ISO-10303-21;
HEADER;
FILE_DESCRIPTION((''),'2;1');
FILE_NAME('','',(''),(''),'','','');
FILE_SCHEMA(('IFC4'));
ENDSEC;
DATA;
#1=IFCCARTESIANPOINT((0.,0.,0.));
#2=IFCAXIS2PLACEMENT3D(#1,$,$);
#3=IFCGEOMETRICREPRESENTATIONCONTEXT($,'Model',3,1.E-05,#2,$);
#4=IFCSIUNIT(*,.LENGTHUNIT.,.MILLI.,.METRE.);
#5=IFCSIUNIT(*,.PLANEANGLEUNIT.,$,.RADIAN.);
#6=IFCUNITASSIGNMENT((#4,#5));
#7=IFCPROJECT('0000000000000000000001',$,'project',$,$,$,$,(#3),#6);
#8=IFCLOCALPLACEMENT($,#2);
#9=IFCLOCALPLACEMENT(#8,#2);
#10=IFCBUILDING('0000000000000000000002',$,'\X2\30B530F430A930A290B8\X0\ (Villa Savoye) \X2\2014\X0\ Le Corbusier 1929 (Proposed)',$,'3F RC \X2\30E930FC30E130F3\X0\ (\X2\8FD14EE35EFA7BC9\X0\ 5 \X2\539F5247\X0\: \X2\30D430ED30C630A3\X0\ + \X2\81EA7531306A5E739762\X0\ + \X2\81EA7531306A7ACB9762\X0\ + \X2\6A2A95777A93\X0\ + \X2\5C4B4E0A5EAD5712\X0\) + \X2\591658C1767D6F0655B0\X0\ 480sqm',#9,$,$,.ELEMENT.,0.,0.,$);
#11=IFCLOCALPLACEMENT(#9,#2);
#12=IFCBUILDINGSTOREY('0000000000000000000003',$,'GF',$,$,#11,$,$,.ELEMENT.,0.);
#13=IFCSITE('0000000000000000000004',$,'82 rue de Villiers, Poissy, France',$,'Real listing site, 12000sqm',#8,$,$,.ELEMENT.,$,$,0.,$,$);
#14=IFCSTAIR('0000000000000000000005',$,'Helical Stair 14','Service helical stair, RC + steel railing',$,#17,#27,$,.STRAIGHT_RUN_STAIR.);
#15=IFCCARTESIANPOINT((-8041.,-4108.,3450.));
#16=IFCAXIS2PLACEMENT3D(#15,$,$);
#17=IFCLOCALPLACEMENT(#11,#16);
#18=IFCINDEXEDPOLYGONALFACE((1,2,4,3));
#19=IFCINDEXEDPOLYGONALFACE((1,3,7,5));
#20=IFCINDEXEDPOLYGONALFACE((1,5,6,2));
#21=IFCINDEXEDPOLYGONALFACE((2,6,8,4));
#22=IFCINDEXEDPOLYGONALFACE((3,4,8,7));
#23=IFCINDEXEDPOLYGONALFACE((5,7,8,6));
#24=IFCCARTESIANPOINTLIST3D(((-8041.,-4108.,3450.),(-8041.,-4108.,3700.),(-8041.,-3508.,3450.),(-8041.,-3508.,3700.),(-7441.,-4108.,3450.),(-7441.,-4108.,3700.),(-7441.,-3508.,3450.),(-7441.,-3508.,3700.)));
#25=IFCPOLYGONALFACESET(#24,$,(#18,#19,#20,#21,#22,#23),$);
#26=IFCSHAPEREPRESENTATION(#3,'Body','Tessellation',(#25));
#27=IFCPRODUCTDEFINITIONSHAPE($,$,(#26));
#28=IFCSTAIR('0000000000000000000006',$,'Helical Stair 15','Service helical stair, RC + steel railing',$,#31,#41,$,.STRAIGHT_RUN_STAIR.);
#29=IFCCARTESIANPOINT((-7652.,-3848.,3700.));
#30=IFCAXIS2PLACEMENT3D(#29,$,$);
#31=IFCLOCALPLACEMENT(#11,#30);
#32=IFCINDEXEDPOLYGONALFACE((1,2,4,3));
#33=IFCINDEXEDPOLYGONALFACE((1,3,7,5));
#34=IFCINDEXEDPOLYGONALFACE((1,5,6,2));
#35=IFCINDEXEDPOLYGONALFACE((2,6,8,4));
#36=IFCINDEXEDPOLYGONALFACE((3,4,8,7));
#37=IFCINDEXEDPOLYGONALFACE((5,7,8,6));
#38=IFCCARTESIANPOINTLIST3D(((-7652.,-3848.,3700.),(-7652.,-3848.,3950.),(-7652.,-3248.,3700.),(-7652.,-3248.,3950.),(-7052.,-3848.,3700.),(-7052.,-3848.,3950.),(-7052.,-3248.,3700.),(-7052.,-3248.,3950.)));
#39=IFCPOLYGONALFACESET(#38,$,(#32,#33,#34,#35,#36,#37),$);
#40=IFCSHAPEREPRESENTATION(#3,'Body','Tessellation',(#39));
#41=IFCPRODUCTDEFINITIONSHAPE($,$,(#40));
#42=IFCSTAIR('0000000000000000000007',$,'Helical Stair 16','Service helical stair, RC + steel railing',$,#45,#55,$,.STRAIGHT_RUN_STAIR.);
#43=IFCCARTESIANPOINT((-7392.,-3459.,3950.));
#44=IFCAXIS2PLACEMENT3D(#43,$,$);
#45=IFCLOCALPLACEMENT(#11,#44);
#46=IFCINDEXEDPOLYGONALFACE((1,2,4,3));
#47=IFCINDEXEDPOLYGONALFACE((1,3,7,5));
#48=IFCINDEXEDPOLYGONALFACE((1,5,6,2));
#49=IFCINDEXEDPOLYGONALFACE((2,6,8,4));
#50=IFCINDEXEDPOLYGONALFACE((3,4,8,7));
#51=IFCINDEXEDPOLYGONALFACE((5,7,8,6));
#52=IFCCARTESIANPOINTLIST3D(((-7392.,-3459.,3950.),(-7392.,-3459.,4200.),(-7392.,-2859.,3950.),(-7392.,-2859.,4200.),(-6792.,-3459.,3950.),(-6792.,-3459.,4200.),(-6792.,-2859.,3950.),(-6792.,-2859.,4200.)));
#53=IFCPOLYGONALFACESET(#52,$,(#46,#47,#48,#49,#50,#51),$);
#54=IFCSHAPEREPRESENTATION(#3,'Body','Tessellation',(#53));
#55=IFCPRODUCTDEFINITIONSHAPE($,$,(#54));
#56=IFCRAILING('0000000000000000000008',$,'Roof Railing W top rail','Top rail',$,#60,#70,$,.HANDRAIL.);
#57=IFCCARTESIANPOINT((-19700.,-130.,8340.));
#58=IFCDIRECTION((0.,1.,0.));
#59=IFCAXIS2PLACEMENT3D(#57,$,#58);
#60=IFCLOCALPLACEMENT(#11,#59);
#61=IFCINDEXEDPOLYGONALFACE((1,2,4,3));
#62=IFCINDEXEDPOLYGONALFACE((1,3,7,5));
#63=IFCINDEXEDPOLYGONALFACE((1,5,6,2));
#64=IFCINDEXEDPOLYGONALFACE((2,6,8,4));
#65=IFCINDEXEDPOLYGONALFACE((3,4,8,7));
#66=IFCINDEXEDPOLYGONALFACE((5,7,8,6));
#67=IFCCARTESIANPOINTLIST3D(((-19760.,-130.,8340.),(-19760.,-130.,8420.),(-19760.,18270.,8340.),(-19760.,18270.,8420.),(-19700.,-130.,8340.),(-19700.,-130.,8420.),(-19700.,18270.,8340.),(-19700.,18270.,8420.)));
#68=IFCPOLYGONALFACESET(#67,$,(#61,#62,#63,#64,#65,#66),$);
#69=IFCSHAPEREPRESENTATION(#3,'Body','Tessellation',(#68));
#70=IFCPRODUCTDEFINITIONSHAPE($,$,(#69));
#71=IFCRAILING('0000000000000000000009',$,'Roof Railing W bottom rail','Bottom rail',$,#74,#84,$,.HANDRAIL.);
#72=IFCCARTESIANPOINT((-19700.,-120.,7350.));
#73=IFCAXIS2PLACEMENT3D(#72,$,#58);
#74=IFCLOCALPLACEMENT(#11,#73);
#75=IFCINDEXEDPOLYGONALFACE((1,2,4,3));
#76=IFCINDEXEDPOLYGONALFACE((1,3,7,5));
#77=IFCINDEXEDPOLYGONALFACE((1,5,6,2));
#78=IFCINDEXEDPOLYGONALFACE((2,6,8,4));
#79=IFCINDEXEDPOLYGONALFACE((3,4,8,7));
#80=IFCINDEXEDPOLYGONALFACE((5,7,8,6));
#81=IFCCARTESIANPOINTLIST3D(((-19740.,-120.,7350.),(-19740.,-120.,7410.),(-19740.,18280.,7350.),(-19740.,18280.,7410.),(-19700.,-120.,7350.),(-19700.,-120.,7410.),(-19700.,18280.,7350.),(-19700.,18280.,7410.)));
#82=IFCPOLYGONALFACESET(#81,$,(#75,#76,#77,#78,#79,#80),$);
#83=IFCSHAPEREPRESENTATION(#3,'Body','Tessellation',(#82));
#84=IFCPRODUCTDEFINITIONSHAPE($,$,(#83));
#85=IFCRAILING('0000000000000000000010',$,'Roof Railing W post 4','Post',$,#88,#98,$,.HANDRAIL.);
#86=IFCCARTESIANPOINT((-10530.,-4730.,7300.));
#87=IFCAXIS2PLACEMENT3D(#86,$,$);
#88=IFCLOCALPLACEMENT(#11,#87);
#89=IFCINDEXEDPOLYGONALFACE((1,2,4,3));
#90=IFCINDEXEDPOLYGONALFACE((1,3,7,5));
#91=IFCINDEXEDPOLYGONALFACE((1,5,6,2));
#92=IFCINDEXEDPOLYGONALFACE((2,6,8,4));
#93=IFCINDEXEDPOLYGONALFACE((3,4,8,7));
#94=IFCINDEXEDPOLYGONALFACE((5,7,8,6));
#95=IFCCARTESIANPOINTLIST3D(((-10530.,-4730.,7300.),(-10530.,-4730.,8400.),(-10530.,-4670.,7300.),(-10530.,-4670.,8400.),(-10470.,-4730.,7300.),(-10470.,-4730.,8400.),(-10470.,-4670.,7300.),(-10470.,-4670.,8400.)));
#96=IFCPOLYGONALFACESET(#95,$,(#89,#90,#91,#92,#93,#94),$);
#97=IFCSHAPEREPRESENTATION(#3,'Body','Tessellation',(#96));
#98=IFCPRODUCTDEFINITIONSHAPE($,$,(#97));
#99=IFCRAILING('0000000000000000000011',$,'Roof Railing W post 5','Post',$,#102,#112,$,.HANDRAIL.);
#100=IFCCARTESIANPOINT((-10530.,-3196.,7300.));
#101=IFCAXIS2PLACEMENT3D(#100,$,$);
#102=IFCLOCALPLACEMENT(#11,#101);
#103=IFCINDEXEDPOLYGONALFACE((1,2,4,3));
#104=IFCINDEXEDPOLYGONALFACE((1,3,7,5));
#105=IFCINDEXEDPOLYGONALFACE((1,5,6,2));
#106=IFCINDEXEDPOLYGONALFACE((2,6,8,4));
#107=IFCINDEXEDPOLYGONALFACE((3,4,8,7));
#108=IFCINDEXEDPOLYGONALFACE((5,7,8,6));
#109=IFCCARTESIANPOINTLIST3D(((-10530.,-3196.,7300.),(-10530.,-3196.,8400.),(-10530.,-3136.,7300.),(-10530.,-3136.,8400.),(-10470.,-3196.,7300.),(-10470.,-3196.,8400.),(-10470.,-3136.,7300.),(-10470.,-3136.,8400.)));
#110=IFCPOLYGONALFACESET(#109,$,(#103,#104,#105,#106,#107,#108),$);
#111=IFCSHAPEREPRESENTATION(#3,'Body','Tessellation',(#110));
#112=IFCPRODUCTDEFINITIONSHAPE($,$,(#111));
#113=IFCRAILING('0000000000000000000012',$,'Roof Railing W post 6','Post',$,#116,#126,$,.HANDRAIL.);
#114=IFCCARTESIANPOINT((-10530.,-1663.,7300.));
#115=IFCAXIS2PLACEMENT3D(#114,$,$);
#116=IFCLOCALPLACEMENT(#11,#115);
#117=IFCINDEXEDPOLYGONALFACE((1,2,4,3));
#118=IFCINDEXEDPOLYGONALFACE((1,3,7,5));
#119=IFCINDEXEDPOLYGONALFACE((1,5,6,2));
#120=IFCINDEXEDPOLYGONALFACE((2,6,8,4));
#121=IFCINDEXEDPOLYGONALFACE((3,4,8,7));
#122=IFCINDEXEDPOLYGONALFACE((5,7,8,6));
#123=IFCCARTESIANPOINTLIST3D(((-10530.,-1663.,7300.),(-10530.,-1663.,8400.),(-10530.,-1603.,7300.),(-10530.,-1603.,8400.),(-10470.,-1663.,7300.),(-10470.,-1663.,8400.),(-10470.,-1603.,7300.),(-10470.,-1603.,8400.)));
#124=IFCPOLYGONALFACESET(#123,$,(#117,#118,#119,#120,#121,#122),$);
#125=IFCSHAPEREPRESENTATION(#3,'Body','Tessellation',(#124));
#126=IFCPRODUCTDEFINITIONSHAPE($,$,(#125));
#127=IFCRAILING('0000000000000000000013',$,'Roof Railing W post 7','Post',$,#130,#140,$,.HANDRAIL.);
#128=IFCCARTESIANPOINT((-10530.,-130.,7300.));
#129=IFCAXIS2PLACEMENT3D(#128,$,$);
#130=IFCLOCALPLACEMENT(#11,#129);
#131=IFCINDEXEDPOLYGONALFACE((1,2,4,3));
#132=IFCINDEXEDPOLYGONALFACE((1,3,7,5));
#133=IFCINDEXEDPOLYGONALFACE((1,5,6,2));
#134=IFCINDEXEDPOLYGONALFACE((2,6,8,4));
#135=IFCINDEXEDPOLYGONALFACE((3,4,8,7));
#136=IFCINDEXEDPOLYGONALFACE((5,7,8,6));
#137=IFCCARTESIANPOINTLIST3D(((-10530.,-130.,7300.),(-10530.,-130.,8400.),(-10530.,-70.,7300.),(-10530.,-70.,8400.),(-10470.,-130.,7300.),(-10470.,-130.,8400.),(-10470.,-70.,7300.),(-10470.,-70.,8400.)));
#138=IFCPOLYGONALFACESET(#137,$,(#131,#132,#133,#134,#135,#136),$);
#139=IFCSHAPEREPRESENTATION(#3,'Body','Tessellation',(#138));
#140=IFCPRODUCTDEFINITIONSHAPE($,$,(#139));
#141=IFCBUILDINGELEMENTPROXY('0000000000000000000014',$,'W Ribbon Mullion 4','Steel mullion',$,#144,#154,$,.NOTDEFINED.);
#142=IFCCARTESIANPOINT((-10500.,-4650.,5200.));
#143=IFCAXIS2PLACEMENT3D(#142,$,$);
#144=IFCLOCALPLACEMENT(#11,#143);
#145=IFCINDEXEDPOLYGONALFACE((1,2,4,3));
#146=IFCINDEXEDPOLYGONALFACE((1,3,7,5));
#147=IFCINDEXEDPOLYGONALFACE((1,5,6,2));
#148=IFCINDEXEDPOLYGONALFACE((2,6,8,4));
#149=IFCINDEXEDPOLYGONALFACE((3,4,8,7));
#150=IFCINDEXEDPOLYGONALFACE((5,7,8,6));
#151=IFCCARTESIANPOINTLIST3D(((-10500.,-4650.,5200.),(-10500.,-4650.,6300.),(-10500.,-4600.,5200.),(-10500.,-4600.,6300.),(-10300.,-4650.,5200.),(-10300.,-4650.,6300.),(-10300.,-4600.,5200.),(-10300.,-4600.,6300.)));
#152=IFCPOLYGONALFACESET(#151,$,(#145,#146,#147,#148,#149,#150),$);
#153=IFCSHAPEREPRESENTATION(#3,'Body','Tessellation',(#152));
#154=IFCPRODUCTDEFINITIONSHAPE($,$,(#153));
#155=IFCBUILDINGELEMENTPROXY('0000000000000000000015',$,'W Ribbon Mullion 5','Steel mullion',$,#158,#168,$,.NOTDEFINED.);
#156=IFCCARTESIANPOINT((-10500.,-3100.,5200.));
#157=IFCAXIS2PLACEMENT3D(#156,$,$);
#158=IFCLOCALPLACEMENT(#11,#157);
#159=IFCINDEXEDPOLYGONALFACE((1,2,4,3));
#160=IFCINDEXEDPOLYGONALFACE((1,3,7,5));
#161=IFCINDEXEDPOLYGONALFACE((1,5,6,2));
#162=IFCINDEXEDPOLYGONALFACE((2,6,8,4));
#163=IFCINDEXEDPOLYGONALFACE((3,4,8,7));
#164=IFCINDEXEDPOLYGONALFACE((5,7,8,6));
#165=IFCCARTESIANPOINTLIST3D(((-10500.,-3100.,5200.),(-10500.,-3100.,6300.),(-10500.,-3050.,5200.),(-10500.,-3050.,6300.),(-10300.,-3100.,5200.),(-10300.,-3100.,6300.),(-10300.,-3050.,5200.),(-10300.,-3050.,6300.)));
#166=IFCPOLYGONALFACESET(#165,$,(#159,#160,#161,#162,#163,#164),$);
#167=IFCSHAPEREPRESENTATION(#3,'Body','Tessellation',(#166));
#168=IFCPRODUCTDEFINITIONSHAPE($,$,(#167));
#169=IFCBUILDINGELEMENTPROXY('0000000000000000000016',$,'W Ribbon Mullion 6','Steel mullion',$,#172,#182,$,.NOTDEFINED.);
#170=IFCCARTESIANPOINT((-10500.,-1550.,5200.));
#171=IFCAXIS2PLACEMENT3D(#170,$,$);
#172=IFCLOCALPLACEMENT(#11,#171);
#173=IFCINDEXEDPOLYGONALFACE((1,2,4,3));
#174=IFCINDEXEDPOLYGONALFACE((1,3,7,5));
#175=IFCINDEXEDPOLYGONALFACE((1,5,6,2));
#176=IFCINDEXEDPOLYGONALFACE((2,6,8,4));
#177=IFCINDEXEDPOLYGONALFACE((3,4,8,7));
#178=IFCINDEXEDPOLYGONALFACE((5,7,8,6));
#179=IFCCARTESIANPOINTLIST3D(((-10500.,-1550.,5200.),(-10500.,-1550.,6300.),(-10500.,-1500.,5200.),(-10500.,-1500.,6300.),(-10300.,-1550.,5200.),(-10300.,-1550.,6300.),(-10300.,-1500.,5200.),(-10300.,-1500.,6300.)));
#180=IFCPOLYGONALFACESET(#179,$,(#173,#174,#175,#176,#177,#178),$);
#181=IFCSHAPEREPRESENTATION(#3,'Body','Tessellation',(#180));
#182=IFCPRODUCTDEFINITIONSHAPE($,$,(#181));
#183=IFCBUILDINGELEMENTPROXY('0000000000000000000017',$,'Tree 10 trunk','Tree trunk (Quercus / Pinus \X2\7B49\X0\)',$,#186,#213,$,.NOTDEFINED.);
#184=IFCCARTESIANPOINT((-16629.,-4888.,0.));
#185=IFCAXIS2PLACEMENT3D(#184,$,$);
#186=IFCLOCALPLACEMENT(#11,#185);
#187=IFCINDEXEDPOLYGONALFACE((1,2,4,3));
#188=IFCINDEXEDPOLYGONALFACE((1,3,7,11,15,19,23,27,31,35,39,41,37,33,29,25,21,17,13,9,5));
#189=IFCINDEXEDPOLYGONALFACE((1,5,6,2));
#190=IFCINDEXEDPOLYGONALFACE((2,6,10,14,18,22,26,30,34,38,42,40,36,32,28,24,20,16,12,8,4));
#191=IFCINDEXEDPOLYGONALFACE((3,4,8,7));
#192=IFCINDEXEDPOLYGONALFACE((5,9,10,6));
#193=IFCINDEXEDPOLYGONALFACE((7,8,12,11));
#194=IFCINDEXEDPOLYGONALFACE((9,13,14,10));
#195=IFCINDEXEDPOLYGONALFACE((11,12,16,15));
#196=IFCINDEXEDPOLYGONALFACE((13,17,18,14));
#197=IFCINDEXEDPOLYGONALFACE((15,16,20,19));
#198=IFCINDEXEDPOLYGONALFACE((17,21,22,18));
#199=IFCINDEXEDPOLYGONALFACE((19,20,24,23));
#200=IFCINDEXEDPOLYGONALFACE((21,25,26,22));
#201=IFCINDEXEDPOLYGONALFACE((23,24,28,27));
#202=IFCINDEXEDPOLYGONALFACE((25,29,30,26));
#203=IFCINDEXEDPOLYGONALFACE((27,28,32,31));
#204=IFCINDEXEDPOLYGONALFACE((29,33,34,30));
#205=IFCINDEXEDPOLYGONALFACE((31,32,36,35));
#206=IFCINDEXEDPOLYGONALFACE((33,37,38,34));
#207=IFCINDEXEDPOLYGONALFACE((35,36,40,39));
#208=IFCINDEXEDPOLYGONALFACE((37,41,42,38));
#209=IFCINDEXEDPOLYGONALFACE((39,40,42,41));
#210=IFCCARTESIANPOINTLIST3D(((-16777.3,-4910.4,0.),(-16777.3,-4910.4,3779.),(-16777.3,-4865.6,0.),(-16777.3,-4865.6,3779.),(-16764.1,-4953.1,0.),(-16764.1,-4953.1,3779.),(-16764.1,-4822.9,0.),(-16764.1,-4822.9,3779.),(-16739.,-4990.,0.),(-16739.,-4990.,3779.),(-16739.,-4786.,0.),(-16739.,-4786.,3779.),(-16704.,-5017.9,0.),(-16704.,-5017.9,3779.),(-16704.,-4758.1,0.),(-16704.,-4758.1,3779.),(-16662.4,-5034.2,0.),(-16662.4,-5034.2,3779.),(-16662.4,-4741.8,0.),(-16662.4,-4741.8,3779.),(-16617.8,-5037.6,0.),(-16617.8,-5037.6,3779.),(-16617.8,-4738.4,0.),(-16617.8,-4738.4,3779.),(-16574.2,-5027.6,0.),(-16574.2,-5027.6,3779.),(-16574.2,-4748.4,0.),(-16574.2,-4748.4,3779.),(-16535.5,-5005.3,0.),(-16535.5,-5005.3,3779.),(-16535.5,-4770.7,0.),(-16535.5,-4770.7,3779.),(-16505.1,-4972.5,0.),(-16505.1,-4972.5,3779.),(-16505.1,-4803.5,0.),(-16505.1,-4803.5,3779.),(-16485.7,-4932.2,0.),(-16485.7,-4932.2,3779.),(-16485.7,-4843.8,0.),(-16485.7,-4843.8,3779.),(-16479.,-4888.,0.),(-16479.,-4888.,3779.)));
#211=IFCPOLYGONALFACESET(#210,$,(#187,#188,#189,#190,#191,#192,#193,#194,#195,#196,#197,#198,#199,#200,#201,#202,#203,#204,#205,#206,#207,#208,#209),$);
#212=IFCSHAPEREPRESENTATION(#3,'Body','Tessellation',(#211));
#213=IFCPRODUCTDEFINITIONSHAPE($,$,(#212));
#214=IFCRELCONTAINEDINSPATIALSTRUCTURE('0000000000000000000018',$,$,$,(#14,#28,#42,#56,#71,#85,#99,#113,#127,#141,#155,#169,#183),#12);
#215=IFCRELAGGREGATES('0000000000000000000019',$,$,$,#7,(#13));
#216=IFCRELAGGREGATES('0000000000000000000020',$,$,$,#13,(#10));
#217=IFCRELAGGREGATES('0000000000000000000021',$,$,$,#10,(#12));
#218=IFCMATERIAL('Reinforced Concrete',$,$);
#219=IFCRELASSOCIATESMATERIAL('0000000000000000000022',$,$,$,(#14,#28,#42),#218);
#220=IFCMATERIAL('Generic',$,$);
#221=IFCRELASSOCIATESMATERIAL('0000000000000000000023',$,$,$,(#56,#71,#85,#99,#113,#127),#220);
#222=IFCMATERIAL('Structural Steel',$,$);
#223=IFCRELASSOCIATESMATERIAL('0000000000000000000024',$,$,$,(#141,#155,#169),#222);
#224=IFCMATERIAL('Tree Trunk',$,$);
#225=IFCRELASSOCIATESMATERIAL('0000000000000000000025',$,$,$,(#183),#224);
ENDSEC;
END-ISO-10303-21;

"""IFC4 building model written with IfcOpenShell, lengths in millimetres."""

from ifc_helpers import new_model, si_unit, frame, frame_2d, origin, origin_2d, place, context, project, spatial, rectangle, circle, extrude, material, element, save


model = new_model("IFC4")

# Units and contexts
model_context = context("Model", 3, precision=1e-05, world=origin())
ifc_project = project(units=[si_unit("LENGTHUNIT", "METRE", prefix="MILLI"), si_unit("PLANEANGLEUNIT", "RADIAN")], contexts=[model_context])

# Site, building, storey
site_placement = place(None, origin())
site = spatial("IfcSite", under=ifc_project, at=site_placement, Name="82 rue de Villiers, Poissy, France", ObjectType="Real listing site, 12000sqm", CompositionType="ELEMENT", RefElevation=0.0)
building_placement = place(site_placement, origin())
building = spatial("IfcBuilding", under=site, at=building_placement, Name="サヴォア邸 (Villa Savoye) — Le Corbusier 1929 (Proposed)", ObjectType="3F RC ラーメン (近代建築 5 原則: ピロティ + 自由な平面 + 自由な立面 + 横長窓 + 屋上庭園) + 外壁白漆喰 480sqm", CompositionType="ELEMENT", ElevationOfRefHeight=0.0, ElevationOfTerrain=0.0)
storey_placement = place(building_placement, origin())
storey = spatial("IfcBuildingStorey", under=building, at=storey_placement, Name="GF", CompositionType="ELEMENT", Elevation=0.0)

# Shared definitions
ifc_material_1 = material(Name="Reinforced Concrete")
ifc_material_2 = material(Name="Generic")

# Stairs
stair_1_placement = place(storey_placement, frame((-8041.0, -4108.0, 3450.0)))
element("IfcStair", 1, at=stair_1_placement, inside=storey, material=ifc_material_1, Name="Helical Stair 14", Description="Service helical stair, RC + steel railing", PredefinedType="STRAIGHT_RUN_STAIR", context=model_context, shape_type="SweptSolid", body=[
    extrude(rectangle(XDim=600.0, YDim=600.0, at=frame_2d((300.0, 300.0))), frame((-8041.0, -4108.0, 3450.0)), (0.0, 0.0, 1.0), 250.0),
])
stair_2_placement = place(storey_placement, frame((-7652.0, -3848.0, 3700.0)))
element("IfcStair", 2, at=stair_2_placement, inside=storey, material=ifc_material_1, Name="Helical Stair 15", Description="Service helical stair, RC + steel railing", PredefinedType="STRAIGHT_RUN_STAIR", context=model_context, shape_type="SweptSolid", body=[
    extrude(rectangle(XDim=600.0, YDim=600.0, at=frame_2d((300.0, 300.0))), frame((-7652.0, -3848.0, 3700.0)), (0.0, 0.0, 1.0), 250.0),
])
stair_3_placement = place(storey_placement, frame((-7392.0, -3459.0, 3950.0)))
element("IfcStair", 3, at=stair_3_placement, inside=storey, material=ifc_material_1, Name="Helical Stair 16", Description="Service helical stair, RC + steel railing", PredefinedType="STRAIGHT_RUN_STAIR", context=model_context, shape_type="SweptSolid", body=[
    extrude(rectangle(XDim=600.0, YDim=600.0, at=frame_2d((300.0, 300.0))), frame((-7392.0, -3459.0, 3950.0)), (0.0, 0.0, 1.0), 250.0),
])

# Railings
railing_1_placement = place(storey_placement, frame((-19700.0, -130.0, 8340.0), x_axis=(0.0, 1.0, 0.0)))
element("IfcRailing", 4, at=railing_1_placement, inside=storey, material=ifc_material_2, Name="Roof Railing W top rail", Description="Top rail", PredefinedType="HANDRAIL", context=model_context, shape_type="SweptSolid", body=[
    extrude(rectangle(XDim=18400.0, YDim=60.0, at=frame_2d((9200.0, 30.0))), frame((-19700.0, -130.0, 8340.0), x_axis=(0.0, 1.0, 0.0)), (0.0, 0.0, 1.0), 80.0),
])
railing_2_placement = place(storey_placement, frame((-19700.0, -120.0, 7350.0), x_axis=(0.0, 1.0, 0.0)))
element("IfcRailing", 5, at=railing_2_placement, inside=storey, material=ifc_material_2, Name="Roof Railing W bottom rail", Description="Bottom rail", PredefinedType="HANDRAIL", context=model_context, shape_type="SweptSolid", body=[
    extrude(rectangle(XDim=18400.0, YDim=40.0, at=frame_2d((9200.0, 20.0))), frame((-19700.0, -120.0, 7350.0), x_axis=(0.0, 1.0, 0.0)), (0.0, 0.0, 1.0), 60.0),
])
railing_3_placement = place(storey_placement, frame((-10530.0, -4730.0, 7300.0)))
element("IfcRailing", 6, at=railing_3_placement, inside=storey, material=ifc_material_2, Name="Roof Railing W post 4", Description="Post", PredefinedType="HANDRAIL", context=model_context, shape_type="SweptSolid", body=[
    extrude(rectangle(XDim=60.0, YDim=60.0, at=frame_2d((30.0, 30.0))), frame((-10530.0, -4730.0, 7300.0)), (0.0, 0.0, 1.0), 1100.0),
])
railing_4_placement = place(storey_placement, frame((-10530.0, -3196.0, 7300.0)))
element("IfcRailing", 7, at=railing_4_placement, inside=storey, material=ifc_material_2, Name="Roof Railing W post 5", Description="Post", PredefinedType="HANDRAIL", context=model_context, shape_type="SweptSolid", body=[
    extrude(rectangle(XDim=60.0, YDim=60.0, at=frame_2d((30.0, 30.0))), frame((-10530.0, -3196.0, 7300.0)), (0.0, 0.0, 1.0), 1100.0),
])
railing_5_placement = place(storey_placement, frame((-10530.0, -1663.0, 7300.0)))
element("IfcRailing", 8, at=railing_5_placement, inside=storey, material=ifc_material_2, Name="Roof Railing W post 6", Description="Post", PredefinedType="HANDRAIL", context=model_context, shape_type="SweptSolid", body=[
    extrude(rectangle(XDim=60.0, YDim=60.0, at=frame_2d((30.0, 30.0))), frame((-10530.0, -1663.0, 7300.0)), (0.0, 0.0, 1.0), 1100.0),
])
railing_6_placement = place(storey_placement, frame((-10530.0, -130.0, 7300.0)))
element("IfcRailing", 9, at=railing_6_placement, inside=storey, material=ifc_material_2, Name="Roof Railing W post 7", Description="Post", PredefinedType="HANDRAIL", context=model_context, shape_type="SweptSolid", body=[
    extrude(rectangle(XDim=60.0, YDim=60.0, at=frame_2d((30.0, 30.0))), frame((-10530.0, -130.0, 7300.0)), (0.0, 0.0, 1.0), 1100.0),
])

# Building element proxies
ifc_material_3 = material(Name="Structural Steel")
proxy_1_placement = place(storey_placement, frame((-10500.0, -4650.0, 5200.0)))
element("IfcBuildingElementProxy", 10, at=proxy_1_placement, inside=storey, material=ifc_material_3, Name="W Ribbon Mullion 4", Description="Steel mullion", PredefinedType="NOTDEFINED", context=model_context, shape_type="SweptSolid", body=[
    extrude(rectangle(XDim=200.0, YDim=50.0, at=frame_2d((100.0, 25.0))), frame((-10500.0, -4650.0, 5200.0)), (0.0, 0.0, 1.0), 1100.0),
])
proxy_2_placement = place(storey_placement, frame((-10500.0, -3100.0, 5200.0)))
element("IfcBuildingElementProxy", 11, at=proxy_2_placement, inside=storey, material=ifc_material_3, Name="W Ribbon Mullion 5", Description="Steel mullion", PredefinedType="NOTDEFINED", context=model_context, shape_type="SweptSolid", body=[
    extrude(rectangle(XDim=200.0, YDim=50.0, at=frame_2d((100.0, 25.0))), frame((-10500.0, -3100.0, 5200.0)), (0.0, 0.0, 1.0), 1100.0),
])
proxy_3_placement = place(storey_placement, frame((-10500.0, -1550.0, 5200.0)))
element("IfcBuildingElementProxy", 12, at=proxy_3_placement, inside=storey, material=ifc_material_3, Name="W Ribbon Mullion 6", Description="Steel mullion", PredefinedType="NOTDEFINED", context=model_context, shape_type="SweptSolid", body=[
    extrude(rectangle(XDim=200.0, YDim=50.0, at=frame_2d((100.0, 25.0))), frame((-10500.0, -1550.0, 5200.0)), (0.0, 0.0, 1.0), 1100.0),
])
ifc_material_4 = material(Name="Tree Trunk")
proxy_4_placement = place(storey_placement, frame((-16629.0, -4888.0, 0.0)))
element("IfcBuildingElementProxy", 13, at=proxy_4_placement, inside=storey, material=ifc_material_4, Name="Tree 10 trunk", Description="Tree trunk (Quercus / Pinus 等)", PredefinedType="NOTDEFINED", context=model_context, shape_type="SweptSolid", body=[
    extrude(circle(Radius=150.0, at=origin_2d()), frame((-16629.0, -4888.0, 0.0)), (0.0, 0.0, 1.0), 3779.0),
])

save(model, "model.ifc")
